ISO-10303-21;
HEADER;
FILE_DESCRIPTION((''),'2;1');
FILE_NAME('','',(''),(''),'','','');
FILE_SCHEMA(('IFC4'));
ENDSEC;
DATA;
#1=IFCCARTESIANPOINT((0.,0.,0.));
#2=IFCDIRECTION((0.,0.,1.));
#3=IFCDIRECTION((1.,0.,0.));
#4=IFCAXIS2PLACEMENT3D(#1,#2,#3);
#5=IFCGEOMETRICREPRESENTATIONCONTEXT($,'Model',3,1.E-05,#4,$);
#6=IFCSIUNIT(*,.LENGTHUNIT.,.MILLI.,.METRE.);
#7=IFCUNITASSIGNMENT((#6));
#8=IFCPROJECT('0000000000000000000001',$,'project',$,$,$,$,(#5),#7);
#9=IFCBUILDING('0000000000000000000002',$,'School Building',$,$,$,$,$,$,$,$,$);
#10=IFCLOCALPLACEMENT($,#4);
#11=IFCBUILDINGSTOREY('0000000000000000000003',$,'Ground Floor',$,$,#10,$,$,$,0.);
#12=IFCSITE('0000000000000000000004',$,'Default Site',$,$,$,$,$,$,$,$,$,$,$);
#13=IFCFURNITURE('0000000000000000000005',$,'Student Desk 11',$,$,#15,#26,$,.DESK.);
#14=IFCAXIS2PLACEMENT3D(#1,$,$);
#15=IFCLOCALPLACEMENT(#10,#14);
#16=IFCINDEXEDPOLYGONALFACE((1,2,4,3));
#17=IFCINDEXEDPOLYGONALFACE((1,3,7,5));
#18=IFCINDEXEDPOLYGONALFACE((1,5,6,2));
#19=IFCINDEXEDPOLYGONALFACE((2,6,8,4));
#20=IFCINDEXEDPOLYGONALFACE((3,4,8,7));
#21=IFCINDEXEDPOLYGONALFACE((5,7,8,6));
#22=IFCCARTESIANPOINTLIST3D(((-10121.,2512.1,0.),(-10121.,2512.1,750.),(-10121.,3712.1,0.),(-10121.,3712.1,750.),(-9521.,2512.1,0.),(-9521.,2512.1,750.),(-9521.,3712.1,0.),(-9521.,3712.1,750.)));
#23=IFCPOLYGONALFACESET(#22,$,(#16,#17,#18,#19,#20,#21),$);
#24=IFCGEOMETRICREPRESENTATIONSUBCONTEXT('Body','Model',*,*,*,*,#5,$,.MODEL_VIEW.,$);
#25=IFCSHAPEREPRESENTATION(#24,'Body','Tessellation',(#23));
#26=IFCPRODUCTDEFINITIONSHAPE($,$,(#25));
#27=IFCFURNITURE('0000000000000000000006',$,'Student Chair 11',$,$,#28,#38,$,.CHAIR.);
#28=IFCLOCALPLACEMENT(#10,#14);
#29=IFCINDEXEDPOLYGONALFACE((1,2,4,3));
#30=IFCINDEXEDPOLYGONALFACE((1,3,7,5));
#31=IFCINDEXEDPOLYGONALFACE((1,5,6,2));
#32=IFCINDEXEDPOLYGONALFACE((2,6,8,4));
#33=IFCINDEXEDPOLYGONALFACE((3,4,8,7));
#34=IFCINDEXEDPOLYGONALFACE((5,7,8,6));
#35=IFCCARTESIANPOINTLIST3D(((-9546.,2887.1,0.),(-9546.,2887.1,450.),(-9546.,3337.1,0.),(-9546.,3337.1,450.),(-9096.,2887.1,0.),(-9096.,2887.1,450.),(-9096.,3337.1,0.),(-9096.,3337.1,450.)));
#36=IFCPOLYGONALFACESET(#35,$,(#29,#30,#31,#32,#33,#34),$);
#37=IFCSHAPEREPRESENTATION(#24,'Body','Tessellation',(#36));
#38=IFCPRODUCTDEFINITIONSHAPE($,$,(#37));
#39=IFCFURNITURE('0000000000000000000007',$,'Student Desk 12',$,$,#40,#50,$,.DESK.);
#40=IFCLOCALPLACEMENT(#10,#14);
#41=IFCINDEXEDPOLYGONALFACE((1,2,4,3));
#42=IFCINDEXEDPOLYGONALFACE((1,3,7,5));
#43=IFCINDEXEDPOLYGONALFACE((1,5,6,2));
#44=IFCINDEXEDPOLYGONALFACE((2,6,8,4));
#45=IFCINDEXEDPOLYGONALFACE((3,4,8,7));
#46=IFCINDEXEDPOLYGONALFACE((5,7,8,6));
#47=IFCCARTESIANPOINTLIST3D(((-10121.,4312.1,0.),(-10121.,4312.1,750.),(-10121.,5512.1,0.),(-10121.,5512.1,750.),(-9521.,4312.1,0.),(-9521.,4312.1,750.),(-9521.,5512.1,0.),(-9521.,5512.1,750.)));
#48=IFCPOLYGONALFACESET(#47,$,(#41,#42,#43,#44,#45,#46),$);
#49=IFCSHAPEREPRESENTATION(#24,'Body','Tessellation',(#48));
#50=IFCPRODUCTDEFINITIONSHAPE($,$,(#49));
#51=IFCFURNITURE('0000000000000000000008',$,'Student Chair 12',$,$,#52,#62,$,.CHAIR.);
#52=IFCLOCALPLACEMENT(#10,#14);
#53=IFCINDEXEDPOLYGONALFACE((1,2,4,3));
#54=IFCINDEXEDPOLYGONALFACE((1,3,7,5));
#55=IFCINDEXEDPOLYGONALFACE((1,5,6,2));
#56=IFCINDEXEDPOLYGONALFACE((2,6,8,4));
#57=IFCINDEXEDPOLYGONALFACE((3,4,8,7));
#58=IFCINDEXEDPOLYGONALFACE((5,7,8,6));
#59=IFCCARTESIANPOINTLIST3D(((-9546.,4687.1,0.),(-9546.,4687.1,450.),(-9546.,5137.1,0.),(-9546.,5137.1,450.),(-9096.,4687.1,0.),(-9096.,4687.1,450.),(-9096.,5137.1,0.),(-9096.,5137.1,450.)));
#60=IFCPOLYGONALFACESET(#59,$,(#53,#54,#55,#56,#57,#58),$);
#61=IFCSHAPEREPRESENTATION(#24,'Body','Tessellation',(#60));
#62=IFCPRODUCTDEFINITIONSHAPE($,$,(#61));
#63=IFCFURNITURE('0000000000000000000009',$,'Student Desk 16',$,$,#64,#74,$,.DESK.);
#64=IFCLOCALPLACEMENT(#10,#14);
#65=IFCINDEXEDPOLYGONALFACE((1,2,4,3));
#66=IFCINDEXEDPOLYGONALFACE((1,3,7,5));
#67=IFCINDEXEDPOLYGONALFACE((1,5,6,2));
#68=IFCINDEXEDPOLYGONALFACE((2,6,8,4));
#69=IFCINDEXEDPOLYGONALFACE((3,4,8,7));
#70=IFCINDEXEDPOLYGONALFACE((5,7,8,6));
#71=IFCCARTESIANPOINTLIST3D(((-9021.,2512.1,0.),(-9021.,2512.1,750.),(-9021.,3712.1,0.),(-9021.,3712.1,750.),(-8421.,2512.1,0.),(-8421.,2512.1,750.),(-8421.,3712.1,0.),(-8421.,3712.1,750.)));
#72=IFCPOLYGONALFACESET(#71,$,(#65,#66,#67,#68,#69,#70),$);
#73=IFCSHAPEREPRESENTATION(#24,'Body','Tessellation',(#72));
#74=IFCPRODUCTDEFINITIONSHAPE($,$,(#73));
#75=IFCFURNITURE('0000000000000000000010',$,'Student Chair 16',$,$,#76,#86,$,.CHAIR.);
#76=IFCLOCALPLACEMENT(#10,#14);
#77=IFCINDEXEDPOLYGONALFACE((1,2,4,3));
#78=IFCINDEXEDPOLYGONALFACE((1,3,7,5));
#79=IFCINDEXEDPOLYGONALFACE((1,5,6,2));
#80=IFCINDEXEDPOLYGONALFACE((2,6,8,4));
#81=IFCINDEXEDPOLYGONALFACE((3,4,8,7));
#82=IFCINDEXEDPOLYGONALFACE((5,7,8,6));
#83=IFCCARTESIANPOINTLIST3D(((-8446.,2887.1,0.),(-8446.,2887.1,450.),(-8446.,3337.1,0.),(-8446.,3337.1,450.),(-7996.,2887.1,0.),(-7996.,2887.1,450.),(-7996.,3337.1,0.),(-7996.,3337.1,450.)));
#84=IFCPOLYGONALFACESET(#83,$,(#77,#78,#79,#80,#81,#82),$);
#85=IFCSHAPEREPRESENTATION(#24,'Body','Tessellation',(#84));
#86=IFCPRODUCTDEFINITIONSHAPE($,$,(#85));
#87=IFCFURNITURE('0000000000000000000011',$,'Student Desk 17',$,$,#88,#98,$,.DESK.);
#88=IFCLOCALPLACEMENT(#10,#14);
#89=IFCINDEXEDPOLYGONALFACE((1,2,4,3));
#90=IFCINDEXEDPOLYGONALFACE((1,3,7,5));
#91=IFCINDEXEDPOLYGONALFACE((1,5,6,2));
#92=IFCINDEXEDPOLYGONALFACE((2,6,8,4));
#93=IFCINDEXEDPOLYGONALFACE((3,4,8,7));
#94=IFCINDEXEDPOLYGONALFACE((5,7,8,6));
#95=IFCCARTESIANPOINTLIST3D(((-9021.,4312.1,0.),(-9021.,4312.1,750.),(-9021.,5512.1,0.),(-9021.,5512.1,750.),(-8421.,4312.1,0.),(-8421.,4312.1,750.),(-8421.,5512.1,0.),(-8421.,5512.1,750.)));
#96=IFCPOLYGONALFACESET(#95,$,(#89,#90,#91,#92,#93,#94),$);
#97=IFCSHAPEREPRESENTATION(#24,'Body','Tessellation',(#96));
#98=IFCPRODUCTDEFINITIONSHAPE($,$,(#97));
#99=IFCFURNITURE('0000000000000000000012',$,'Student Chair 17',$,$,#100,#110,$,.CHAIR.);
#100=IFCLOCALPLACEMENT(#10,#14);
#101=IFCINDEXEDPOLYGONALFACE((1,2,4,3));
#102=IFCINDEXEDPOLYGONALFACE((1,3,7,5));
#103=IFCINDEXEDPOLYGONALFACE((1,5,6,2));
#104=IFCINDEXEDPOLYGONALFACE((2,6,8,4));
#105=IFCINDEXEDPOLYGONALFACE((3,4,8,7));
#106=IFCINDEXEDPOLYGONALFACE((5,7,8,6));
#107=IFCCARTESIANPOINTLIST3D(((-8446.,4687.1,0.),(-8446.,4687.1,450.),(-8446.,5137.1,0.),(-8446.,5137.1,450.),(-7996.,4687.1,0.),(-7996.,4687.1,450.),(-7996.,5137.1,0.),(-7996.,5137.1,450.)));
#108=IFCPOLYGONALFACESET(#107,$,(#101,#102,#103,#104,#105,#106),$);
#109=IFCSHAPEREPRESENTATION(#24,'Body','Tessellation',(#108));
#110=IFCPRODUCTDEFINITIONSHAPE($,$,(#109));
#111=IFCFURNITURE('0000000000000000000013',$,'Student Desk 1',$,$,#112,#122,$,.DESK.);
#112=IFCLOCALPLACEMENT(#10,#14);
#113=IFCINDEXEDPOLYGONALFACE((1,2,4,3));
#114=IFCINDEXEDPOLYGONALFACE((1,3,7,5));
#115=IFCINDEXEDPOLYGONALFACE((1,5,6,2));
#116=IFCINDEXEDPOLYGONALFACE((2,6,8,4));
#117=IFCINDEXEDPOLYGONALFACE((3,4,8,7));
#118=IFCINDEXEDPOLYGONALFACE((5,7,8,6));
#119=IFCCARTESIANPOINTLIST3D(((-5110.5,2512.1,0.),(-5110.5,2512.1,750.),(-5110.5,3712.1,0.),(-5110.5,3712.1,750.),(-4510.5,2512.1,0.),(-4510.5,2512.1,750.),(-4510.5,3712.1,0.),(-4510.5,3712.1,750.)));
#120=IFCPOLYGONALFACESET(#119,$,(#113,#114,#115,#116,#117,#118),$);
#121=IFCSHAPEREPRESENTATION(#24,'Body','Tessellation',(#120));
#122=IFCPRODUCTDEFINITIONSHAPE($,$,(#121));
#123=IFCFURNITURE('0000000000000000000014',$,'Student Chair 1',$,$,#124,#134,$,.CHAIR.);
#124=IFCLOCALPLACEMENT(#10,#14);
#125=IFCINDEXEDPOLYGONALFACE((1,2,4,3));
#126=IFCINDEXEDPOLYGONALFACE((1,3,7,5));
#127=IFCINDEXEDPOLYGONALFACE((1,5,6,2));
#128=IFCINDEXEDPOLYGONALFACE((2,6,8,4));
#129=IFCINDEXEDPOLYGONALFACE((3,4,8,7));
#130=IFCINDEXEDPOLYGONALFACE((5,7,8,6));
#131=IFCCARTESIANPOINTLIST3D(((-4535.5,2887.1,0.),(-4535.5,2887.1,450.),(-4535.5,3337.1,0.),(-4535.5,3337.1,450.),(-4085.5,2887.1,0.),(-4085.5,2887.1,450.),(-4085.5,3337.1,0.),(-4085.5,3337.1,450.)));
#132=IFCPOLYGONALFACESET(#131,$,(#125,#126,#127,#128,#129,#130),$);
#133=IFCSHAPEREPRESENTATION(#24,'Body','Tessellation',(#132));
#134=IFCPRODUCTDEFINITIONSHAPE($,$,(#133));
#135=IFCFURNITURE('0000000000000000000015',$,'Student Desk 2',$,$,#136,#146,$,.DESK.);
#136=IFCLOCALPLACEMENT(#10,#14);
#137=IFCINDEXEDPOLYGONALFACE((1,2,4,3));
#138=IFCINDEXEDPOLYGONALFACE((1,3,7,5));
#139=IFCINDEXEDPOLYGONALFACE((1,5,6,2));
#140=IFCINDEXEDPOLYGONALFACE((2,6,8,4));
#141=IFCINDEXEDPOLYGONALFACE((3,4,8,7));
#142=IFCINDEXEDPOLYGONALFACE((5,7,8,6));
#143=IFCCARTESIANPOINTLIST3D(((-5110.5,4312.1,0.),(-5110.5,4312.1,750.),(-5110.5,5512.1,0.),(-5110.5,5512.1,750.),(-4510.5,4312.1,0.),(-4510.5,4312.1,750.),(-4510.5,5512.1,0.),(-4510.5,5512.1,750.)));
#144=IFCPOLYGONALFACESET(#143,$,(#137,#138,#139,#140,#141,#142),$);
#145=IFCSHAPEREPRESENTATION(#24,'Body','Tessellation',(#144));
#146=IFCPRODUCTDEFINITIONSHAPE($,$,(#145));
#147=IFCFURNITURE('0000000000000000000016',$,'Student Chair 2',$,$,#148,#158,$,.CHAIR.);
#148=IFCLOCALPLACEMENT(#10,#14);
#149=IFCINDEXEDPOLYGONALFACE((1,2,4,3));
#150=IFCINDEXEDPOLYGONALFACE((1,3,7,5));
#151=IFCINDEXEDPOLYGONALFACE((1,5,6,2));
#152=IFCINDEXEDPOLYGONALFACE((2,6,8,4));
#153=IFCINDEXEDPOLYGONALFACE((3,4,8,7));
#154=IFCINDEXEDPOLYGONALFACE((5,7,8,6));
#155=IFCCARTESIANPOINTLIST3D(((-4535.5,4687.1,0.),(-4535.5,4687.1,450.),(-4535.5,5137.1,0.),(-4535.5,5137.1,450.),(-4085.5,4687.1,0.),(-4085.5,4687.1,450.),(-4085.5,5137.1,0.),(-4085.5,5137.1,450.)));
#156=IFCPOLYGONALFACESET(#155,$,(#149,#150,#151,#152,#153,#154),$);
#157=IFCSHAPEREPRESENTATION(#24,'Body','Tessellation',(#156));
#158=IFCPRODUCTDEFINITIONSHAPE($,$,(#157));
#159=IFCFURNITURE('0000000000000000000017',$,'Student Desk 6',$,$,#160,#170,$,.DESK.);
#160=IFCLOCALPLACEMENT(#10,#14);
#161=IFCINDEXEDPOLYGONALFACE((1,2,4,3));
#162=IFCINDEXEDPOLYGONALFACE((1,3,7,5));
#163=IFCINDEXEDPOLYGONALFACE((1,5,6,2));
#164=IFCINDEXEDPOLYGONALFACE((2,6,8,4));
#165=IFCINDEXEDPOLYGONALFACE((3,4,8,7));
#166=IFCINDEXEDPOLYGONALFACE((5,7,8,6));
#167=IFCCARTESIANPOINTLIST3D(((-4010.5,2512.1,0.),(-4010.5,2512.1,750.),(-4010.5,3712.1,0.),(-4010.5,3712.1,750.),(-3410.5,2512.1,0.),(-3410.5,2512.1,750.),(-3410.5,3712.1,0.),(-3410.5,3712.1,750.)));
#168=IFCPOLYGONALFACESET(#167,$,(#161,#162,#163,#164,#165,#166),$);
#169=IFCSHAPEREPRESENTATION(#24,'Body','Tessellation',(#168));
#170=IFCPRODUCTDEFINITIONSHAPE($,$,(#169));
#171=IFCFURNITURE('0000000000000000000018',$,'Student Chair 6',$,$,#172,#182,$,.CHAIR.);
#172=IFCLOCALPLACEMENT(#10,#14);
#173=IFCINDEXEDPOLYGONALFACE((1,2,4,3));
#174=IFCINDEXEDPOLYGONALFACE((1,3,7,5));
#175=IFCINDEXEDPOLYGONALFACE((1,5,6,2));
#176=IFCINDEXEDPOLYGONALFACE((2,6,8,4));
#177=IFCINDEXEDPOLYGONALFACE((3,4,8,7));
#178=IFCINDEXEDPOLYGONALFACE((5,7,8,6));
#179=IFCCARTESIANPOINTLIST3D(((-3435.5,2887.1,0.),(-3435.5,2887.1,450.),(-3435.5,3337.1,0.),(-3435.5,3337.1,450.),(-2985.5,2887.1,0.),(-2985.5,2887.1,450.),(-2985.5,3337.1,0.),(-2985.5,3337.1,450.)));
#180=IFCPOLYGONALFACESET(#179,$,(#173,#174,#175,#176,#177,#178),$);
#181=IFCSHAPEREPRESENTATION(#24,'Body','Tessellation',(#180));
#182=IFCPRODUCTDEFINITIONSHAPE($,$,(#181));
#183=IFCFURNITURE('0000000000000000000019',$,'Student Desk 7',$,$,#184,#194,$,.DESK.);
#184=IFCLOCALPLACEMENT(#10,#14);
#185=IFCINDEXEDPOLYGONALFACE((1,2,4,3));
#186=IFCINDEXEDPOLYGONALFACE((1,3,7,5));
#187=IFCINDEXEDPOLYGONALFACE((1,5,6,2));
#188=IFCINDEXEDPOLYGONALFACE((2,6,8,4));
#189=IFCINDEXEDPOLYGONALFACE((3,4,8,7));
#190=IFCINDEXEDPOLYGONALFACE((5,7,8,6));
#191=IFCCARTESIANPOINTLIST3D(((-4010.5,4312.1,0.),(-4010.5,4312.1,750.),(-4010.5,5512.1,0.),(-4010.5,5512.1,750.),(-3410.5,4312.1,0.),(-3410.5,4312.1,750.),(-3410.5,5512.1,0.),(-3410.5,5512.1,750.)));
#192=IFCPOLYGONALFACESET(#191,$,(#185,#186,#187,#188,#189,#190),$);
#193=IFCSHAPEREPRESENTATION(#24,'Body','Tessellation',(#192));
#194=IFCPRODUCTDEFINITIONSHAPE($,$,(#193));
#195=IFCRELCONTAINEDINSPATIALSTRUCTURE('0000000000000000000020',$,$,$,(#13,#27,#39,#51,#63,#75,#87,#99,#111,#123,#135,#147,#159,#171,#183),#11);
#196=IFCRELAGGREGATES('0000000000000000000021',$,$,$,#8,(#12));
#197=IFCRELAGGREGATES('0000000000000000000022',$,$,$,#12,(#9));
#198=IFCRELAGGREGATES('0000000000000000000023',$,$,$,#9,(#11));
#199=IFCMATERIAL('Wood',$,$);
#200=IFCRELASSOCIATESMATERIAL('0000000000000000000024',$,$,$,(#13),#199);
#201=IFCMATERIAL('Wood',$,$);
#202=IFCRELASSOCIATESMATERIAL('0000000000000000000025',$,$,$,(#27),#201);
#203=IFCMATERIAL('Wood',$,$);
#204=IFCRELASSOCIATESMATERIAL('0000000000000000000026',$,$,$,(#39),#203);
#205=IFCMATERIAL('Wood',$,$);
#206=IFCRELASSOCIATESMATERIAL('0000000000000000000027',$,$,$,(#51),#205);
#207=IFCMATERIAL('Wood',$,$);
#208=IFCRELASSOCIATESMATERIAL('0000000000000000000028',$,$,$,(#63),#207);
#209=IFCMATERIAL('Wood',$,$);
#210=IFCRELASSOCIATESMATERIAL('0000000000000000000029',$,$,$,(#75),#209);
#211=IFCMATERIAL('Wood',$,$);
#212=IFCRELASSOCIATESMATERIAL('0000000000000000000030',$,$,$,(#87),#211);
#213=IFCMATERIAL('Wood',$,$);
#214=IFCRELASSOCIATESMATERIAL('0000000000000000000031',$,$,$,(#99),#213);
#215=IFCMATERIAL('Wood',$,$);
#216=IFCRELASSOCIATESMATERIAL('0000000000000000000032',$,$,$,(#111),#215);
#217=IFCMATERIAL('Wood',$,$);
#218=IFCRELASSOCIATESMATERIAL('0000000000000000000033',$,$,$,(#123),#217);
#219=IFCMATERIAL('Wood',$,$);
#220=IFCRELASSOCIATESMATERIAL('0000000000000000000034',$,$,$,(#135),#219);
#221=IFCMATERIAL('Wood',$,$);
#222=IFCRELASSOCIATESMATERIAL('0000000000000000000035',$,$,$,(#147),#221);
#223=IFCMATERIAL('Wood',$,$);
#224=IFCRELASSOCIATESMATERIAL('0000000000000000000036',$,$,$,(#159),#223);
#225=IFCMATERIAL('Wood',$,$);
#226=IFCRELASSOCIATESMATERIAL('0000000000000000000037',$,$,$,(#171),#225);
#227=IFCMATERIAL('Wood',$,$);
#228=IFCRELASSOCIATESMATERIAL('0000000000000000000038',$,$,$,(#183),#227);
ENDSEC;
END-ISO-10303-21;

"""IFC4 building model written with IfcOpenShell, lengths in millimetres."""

from ifc_helpers import new_model, si_unit, frame, origin_with_axes, origin_2d, place, context, subcontext, project, spatial, rectangle, extrude, material, element, save


model = new_model("IFC4")

# Units and contexts
model_context = context("Model", 3, precision=1e-05, world=origin_with_axes())
body_context = subcontext(model_context, "Body", "Model", "MODEL_VIEW")
ifc_project = project(units=[si_unit("LENGTHUNIT", "METRE", prefix="MILLI")], contexts=[model_context])

# Site, building, storey
site = spatial("IfcSite", under=ifc_project, Name="Default Site")
building = spatial("IfcBuilding", under=site, Name="School Building")
storey_placement = place(None, origin_with_axes())
storey = spatial("IfcBuildingStorey", under=building, at=storey_placement, Name="Ground Floor", Elevation=0.0)

# Furniture
ifc_material_1 = material(Name="Wood")
furniture_1_placement = place(storey_placement, frame((-9821.0, 3112.1, 0.0), z_axis=(0.0, 0.0, 1.0), x_axis=(0.0, 1.0, 0.0)))
element("IfcFurniture", 1, at=furniture_1_placement, inside=storey, material=ifc_material_1, Name="Student Desk 11", PredefinedType="DESK", context=body_context, shape_type="SweptSolid", body=[
    extrude(rectangle(XDim=1200.0, YDim=600.0, at=origin_2d()), origin_with_axes(), (0.0, 0.0, 1.0), 750.0),
])
ifc_material_2 = material(Name="Wood")
furniture_2_placement = place(storey_placement, frame((-9321.0, 3112.1, 0.0), z_axis=(0.0, 0.0, 1.0), x_axis=(1.0, 0.0, 0.0)))
element("IfcFurniture", 2, at=furniture_2_placement, inside=storey, material=ifc_material_2, Name="Student Chair 11", PredefinedType="CHAIR", context=body_context, shape_type="SweptSolid", body=[
    extrude(rectangle(XDim=450.0, YDim=450.0, at=origin_2d()), origin_with_axes(), (0.0, 0.0, 1.0), 450.0),
])
ifc_material_3 = material(Name="Wood")
furniture_3_placement = place(storey_placement, frame((-9821.0, 4912.1, 0.0), z_axis=(0.0, 0.0, 1.0), x_axis=(0.0, 1.0, 0.0)))
element("IfcFurniture", 3, at=furniture_3_placement, inside=storey, material=ifc_material_3, Name="Student Desk 12", PredefinedType="DESK", context=body_context, shape_type="SweptSolid", body=[
    extrude(rectangle(XDim=1200.0, YDim=600.0, at=origin_2d()), origin_with_axes(), (0.0, 0.0, 1.0), 750.0),
])
ifc_material_4 = material(Name="Wood")
furniture_4_placement = place(storey_placement, frame((-9321.0, 4912.1, 0.0), z_axis=(0.0, 0.0, 1.0), x_axis=(1.0, 0.0, 0.0)))
element("IfcFurniture", 4, at=furniture_4_placement, inside=storey, material=ifc_material_4, Name="Student Chair 12", PredefinedType="CHAIR", context=body_context, shape_type="SweptSolid", body=[
    extrude(rectangle(XDim=450.0, YDim=450.0, at=origin_2d()), origin_with_axes(), (0.0, 0.0, 1.0), 450.0),
])
ifc_material_5 = material(Name="Wood")
furniture_5_placement = place(storey_placement, frame((-8721.0, 3112.1, 0.0), z_axis=(0.0, 0.0, 1.0), x_axis=(0.0, 1.0, 0.0)))
element("IfcFurniture", 5, at=furniture_5_placement, inside=storey, material=ifc_material_5, Name="Student Desk 16", PredefinedType="DESK", context=body_context, shape_type="SweptSolid", body=[
    extrude(rectangle(XDim=1200.0, YDim=600.0, at=origin_2d()), origin_with_axes(), (0.0, 0.0, 1.0), 750.0),
])
ifc_material_6 = material(Name="Wood")
furniture_6_placement = place(storey_placement, frame((-8221.0, 3112.1, 0.0), z_axis=(0.0, 0.0, 1.0), x_axis=(1.0, 0.0, 0.0)))
element("IfcFurniture", 6, at=furniture_6_placement, inside=storey, material=ifc_material_6, Name="Student Chair 16", PredefinedType="CHAIR", context=body_context, shape_type="SweptSolid", body=[
    extrude(rectangle(XDim=450.0, YDim=450.0, at=origin_2d()), origin_with_axes(), (0.0, 0.0, 1.0), 450.0),
])
ifc_material_7 = material(Name="Wood")
furniture_7_placement = place(storey_placement, frame((-8721.0, 4912.1, 0.0), z_axis=(0.0, 0.0, 1.0), x_axis=(0.0, 1.0, 0.0)))
element("IfcFurniture", 7, at=furniture_7_placement, inside=storey, material=ifc_material_7, Name="Student Desk 17", PredefinedType="DESK", context=body_context, shape_type="SweptSolid", body=[
    extrude(rectangle(XDim=1200.0, YDim=600.0, at=origin_2d()), origin_with_axes(), (0.0, 0.0, 1.0), 750.0),
])
ifc_material_8 = material(Name="Wood")
furniture_8_placement = place(storey_placement, frame((-8221.0, 4912.1, 0.0), z_axis=(0.0, 0.0, 1.0), x_axis=(1.0, 0.0, 0.0)))
element("IfcFurniture", 8, at=furniture_8_placement, inside=storey, material=ifc_material_8, Name="Student Chair 17", PredefinedType="CHAIR", context=body_context, shape_type="SweptSolid", body=[
    extrude(rectangle(XDim=450.0, YDim=450.0, at=origin_2d()), origin_with_axes(), (0.0, 0.0, 1.0), 450.0),
])
ifc_material_9 = material(Name="Wood")
furniture_9_placement = place(storey_placement, frame((-4810.5, 3112.1, 0.0), z_axis=(0.0, 0.0, 1.0), x_axis=(0.0, 1.0, 0.0)))
element("IfcFurniture", 9, at=furniture_9_placement, inside=storey, material=ifc_material_9, Name="Student Desk 1", PredefinedType="DESK", context=body_context, shape_type="SweptSolid", body=[
    extrude(rectangle(XDim=1200.0, YDim=600.0, at=origin_2d()), origin_with_axes(), (0.0, 0.0, 1.0), 750.0),
])
ifc_material_10 = material(Name="Wood")
furniture_10_placement = place(storey_placement, frame((-4310.5, 3112.1, 0.0), z_axis=(0.0, 0.0, 1.0), x_axis=(1.0, 0.0, 0.0)))
element("IfcFurniture", 10, at=furniture_10_placement, inside=storey, material=ifc_material_10, Name="Student Chair 1", PredefinedType="CHAIR", context=body_context, shape_type="SweptSolid", body=[
    extrude(rectangle(XDim=450.0, YDim=450.0, at=origin_2d()), origin_with_axes(), (0.0, 0.0, 1.0), 450.0),
])
ifc_material_11 = material(Name="Wood")
furniture_11_placement = place(storey_placement, frame((-4810.5, 4912.1, 0.0), z_axis=(0.0, 0.0, 1.0), x_axis=(0.0, 1.0, 0.0)))
element("IfcFurniture", 11, at=furniture_11_placement, inside=storey, material=ifc_material_11, Name="Student Desk 2", PredefinedType="DESK", context=body_context, shape_type="SweptSolid", body=[
    extrude(rectangle(XDim=1200.0, YDim=600.0, at=origin_2d()), origin_with_axes(), (0.0, 0.0, 1.0), 750.0),
])
ifc_material_12 = material(Name="Wood")
furniture_12_placement = place(storey_placement, frame((-4310.5, 4912.1, 0.0), z_axis=(0.0, 0.0, 1.0), x_axis=(1.0, 0.0, 0.0)))
element("IfcFurniture", 12, at=furniture_12_placement, inside=storey, material=ifc_material_12, Name="Student Chair 2", PredefinedType="CHAIR", context=body_context, shape_type="SweptSolid", body=[
    extrude(rectangle(XDim=450.0, YDim=450.0, at=origin_2d()), origin_with_axes(), (0.0, 0.0, 1.0), 450.0),
])
ifc_material_13 = material(Name="Wood")
furniture_13_placement = place(storey_placement, frame((-3710.5, 3112.1, 0.0), z_axis=(0.0, 0.0, 1.0), x_axis=(0.0, 1.0, 0.0)))
element("IfcFurniture", 13, at=furniture_13_placement, inside=storey, material=ifc_material_13, Name="Student Desk 6", PredefinedType="DESK", context=body_context, shape_type="SweptSolid", body=[
    extrude(rectangle(XDim=1200.0, YDim=600.0, at=origin_2d()), origin_with_axes(), (0.0, 0.0, 1.0), 750.0),
])
ifc_material_14 = material(Name="Wood")
furniture_14_placement = place(storey_placement, frame((-3210.5, 3112.1, 0.0), z_axis=(0.0, 0.0, 1.0), x_axis=(1.0, 0.0, 0.0)))
element("IfcFurniture", 14, at=furniture_14_placement, inside=storey, material=ifc_material_14, Name="Student Chair 6", PredefinedType="CHAIR", context=body_context, shape_type="SweptSolid", body=[
    extrude(rectangle(XDim=450.0, YDim=450.0, at=origin_2d()), origin_with_axes(), (0.0, 0.0, 1.0), 450.0),
])
ifc_material_15 = material(Name="Wood")
furniture_15_placement = place(storey_placement, frame((-3710.5, 4912.1, 0.0), z_axis=(0.0, 0.0, 1.0), x_axis=(0.0, 1.0, 0.0)))
element("IfcFurniture", 15, at=furniture_15_placement, inside=storey, material=ifc_material_15, Name="Student Desk 7", PredefinedType="DESK", context=body_context, shape_type="SweptSolid", body=[
    extrude(rectangle(XDim=1200.0, YDim=600.0, at=origin_2d()), origin_with_axes(), (0.0, 0.0, 1.0), 750.0),
])

save(model, "model.ifc")
